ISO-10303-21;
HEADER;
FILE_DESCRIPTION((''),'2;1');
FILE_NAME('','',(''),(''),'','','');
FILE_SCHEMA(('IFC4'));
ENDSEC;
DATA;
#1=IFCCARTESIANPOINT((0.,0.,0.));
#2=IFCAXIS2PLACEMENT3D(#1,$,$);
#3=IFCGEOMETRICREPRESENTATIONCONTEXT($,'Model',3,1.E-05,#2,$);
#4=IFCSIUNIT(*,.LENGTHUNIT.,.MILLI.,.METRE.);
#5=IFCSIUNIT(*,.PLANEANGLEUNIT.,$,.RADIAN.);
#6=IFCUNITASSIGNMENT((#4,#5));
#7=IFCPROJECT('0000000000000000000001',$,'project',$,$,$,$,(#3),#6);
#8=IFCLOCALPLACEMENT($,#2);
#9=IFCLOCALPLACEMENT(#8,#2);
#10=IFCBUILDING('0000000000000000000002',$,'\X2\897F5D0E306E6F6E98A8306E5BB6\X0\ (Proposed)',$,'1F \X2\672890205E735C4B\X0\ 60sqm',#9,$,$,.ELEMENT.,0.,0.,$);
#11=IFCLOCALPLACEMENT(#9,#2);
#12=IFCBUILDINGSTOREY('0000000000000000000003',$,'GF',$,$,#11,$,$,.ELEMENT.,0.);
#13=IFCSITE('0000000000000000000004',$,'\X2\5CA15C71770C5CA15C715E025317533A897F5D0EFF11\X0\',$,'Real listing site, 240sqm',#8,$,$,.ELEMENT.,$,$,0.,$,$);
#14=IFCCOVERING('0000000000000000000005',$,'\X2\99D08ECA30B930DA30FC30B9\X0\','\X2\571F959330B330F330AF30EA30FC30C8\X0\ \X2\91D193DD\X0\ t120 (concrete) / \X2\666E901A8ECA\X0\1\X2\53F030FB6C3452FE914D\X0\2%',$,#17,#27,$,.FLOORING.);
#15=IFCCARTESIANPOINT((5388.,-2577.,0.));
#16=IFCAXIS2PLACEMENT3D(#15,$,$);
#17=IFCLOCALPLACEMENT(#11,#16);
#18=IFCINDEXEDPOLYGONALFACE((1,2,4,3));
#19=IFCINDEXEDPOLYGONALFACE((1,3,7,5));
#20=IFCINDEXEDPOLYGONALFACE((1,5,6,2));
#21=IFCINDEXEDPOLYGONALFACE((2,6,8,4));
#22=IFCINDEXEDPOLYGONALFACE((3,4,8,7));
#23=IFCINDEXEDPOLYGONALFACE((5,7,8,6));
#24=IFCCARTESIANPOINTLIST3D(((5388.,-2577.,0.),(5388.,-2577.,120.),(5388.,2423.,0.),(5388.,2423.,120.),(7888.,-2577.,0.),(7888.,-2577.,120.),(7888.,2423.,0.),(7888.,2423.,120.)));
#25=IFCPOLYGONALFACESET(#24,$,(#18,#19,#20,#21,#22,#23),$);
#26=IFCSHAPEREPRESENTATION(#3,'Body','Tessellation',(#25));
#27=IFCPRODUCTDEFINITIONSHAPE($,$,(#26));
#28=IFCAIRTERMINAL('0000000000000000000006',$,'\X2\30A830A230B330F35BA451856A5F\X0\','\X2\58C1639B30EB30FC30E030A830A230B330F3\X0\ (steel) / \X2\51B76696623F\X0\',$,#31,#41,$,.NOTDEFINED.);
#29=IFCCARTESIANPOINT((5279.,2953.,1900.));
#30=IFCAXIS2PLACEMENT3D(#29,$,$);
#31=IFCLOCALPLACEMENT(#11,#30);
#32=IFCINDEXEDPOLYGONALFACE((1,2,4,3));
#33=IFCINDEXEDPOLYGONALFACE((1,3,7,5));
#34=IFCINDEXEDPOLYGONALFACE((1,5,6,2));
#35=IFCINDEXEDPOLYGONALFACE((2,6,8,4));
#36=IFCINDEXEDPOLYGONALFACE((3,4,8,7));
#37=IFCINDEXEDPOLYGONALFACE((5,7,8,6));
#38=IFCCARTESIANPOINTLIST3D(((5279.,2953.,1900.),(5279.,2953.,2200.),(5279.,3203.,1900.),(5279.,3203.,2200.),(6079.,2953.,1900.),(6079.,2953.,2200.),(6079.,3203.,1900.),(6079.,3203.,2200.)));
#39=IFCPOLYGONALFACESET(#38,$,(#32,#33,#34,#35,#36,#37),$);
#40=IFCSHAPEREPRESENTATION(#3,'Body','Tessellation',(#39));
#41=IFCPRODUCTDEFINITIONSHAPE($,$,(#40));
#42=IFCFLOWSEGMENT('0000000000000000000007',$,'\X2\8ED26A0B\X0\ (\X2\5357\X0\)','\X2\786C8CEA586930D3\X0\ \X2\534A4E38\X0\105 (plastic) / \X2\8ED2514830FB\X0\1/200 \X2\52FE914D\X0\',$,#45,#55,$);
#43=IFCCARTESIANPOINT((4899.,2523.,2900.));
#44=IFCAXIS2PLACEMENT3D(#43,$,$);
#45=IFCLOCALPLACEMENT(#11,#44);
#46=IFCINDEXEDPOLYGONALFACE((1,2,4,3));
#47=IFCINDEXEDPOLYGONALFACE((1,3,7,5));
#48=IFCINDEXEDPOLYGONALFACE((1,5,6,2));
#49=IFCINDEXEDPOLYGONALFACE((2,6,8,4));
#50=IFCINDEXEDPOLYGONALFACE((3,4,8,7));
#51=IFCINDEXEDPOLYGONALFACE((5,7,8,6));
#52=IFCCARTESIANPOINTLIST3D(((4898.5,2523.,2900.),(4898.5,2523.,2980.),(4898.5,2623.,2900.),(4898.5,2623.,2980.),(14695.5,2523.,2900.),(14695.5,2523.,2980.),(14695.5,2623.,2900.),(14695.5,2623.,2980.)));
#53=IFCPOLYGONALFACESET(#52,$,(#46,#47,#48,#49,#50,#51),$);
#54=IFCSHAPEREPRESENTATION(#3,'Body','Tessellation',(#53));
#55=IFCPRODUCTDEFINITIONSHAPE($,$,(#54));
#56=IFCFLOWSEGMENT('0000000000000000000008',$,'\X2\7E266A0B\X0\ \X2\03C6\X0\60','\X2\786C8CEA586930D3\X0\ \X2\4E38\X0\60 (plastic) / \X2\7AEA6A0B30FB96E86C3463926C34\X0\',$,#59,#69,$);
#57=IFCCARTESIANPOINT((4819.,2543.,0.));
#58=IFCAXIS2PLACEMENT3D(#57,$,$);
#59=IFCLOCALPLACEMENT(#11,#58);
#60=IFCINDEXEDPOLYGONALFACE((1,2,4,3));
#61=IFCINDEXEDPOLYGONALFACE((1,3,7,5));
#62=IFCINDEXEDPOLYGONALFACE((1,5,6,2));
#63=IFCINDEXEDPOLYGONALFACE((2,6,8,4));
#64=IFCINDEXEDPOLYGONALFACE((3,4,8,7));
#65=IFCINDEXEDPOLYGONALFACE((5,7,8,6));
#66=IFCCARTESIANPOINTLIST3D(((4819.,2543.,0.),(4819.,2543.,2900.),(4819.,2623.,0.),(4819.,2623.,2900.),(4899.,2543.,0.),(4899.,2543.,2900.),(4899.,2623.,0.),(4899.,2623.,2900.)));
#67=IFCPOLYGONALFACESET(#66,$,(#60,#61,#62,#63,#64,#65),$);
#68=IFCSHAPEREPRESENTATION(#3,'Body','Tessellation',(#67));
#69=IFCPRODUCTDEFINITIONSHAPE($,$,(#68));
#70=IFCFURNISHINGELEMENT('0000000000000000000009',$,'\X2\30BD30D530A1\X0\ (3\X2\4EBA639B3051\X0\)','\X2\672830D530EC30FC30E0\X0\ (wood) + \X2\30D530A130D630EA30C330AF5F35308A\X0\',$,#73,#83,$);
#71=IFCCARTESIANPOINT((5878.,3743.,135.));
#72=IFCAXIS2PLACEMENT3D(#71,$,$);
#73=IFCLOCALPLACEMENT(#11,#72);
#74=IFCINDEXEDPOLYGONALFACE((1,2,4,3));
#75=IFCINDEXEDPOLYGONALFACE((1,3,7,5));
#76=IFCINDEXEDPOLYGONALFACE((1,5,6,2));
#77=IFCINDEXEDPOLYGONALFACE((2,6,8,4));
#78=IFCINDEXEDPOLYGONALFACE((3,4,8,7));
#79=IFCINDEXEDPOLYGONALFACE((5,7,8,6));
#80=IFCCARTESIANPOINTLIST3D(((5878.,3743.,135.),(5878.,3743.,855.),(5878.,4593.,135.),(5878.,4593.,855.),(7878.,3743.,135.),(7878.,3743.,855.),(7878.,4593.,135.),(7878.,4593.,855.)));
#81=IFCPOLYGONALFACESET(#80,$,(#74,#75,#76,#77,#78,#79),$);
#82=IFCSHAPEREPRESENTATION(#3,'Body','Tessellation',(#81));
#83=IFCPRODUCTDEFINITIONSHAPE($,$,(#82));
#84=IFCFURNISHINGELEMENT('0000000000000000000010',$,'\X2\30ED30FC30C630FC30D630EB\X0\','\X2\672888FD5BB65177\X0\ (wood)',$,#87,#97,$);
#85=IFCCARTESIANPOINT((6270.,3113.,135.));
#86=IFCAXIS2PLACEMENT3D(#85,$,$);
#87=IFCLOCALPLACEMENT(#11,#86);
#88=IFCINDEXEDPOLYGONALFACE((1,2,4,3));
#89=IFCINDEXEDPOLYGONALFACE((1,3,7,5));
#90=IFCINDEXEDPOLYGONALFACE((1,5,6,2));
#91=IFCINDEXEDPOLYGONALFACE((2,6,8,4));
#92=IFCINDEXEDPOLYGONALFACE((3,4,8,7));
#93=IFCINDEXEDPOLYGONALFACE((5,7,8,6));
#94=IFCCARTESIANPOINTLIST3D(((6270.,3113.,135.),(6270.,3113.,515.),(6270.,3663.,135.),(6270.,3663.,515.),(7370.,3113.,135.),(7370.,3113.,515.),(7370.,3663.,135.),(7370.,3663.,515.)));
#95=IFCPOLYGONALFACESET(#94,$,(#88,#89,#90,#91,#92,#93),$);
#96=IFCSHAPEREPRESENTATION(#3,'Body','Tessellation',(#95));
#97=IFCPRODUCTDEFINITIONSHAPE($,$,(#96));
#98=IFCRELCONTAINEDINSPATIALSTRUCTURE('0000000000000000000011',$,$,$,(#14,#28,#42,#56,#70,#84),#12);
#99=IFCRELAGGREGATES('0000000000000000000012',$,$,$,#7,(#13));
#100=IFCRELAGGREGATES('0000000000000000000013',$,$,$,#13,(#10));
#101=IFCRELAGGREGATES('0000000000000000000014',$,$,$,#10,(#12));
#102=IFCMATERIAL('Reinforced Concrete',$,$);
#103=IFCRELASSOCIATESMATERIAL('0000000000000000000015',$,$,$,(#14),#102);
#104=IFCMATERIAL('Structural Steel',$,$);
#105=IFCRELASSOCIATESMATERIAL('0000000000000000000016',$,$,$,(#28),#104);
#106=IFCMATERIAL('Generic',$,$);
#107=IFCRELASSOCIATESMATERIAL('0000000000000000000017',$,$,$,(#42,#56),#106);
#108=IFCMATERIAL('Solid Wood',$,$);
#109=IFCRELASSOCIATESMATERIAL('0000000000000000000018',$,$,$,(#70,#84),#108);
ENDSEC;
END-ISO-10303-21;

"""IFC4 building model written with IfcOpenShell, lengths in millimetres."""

from ifc_helpers import new_model, si_unit, frame, frame_2d, origin, place, context, project, spatial, rectangle, extrude, material, element, save


model = new_model("IFC4")

# Units and contexts
model_context = context("Model", 3, precision=1e-05, world=origin())
ifc_project = project(units=[si_unit("LENGTHUNIT", "METRE", prefix="MILLI"), si_unit("PLANEANGLEUNIT", "RADIAN")], contexts=[model_context])

# Site, building, storey
site_placement = place(None, origin())
site = spatial("IfcSite", under=ifc_project, at=site_placement, Name="岡山県岡山市北区西崎１", ObjectType="Real listing site, 240sqm", CompositionType="ELEMENT", RefElevation=0.0)
building_placement = place(site_placement, origin())
building = spatial("IfcBuilding", under=site, at=building_placement, Name="西崎の潮風の家 (Proposed)", ObjectType="1F 木造平屋 60sqm", CompositionType="ELEMENT", ElevationOfRefHeight=0.0, ElevationOfTerrain=0.0)
storey_placement = place(building_placement, origin())
storey = spatial("IfcBuildingStorey", under=building, at=storey_placement, Name="GF", CompositionType="ELEMENT", Elevation=0.0)

# Shared definitions
ifc_material_1 = material(Name="Solid Wood")

# Shared definitions
ifc_material_2 = material(Name="Reinforced Concrete")

# Shared definitions
ifc_material_3 = material(Name="Structural Steel")

# Covering
ifc_material_4 = material(Name="Generic")
covering_1_placement = place(storey_placement, frame((5388.0, -2577.0, 0.0)))
element("IfcCovering", 1, at=covering_1_placement, inside=storey, material=ifc_material_2, Name="駐車スペース", Description="土間コンクリート 金鏝 t120 (concrete) / 普通車1台・水勾配2%", PredefinedType="FLOORING", context=model_context, shape_type="SweptSolid", body=[
    extrude(rectangle(XDim=2500.0, YDim=5000.0, at=frame_2d((1250.0, 2500.0))), frame((5388.0, -2577.0, 0.0)), (0.0, 0.0, 1.0), 120.0),
])

# Air terminal
air_terminal_placement = place(storey_placement, frame((5279.0, 2953.0, 1900.0)))
element("IfcAirTerminal", 2, at=air_terminal_placement, inside=storey, material=ifc_material_3, Name="エアコン室内機", Description="壁掛ルームエアコン (steel) / 冷暖房", PredefinedType="NOTDEFINED", context=model_context, shape_type="SweptSolid", body=[
    extrude(rectangle(XDim=800.0, YDim=250.0, at=frame_2d((400.0, 125.0))), frame((5279.0, 2953.0, 1900.0)), (0.0, 0.0, 1.0), 300.0),
])

# Flow segments
flow_segment_1_placement = place(storey_placement, frame((4899.0, 2523.0, 2900.0)))
element("IfcFlowSegment", 3, at=flow_segment_1_placement, inside=storey, material=ifc_material_4, Name="軒樋 (南)", Description="硬質塩ビ 半丸105 (plastic) / 軒先・1/200 勾配", context=model_context, shape_type="SweptSolid", body=[
    extrude(rectangle(XDim=9797.0, YDim=100.0, at=frame_2d((4898.0, 50.0))), frame((4899.0, 2523.0, 2900.0)), (0.0, 0.0, 1.0), 80.0),
])
flow_segment_2_placement = place(storey_placement, frame((4819.0, 2543.0, 0.0)))
element("IfcFlowSegment", 4, at=flow_segment_2_placement, inside=storey, material=ifc_material_4, Name="縦樋 φ60", Description="硬質塩ビ 丸60 (plastic) / 竪樋・雨水排水", context=model_context, shape_type="SweptSolid", body=[
    extrude(rectangle(XDim=80.0, YDim=80.0, at=frame_2d((40.0, 40.0))), frame((4819.0, 2543.0, 0.0)), (0.0, 0.0, 1.0), 2900.0),
])

# Furnishing elements
furnishing_1_placement = place(storey_placement, frame((5878.0, 3743.0, 135.0)))
element("IfcFurnishingElement", 5, at=furnishing_1_placement, inside=storey, material=ifc_material_1, Name="ソファ (3人掛け)", Description="木フレーム (wood) + ファブリック張り", context=model_context, shape_type="SweptSolid", body=[
    extrude(rectangle(XDim=2000.0, YDim=850.0, at=frame_2d((1000.0, 425.0))), frame((5878.0, 3743.0, 135.0)), (0.0, 0.0, 1.0), 720.0),
])
furnishing_2_placement = place(storey_placement, frame((6270.0, 3113.0, 135.0)))
element("IfcFurnishingElement", 6, at=furnishing_2_placement, inside=storey, material=ifc_material_1, Name="ローテーブル", Description="木製家具 (wood)", context=model_context, shape_type="SweptSolid", body=[
    extrude(rectangle(XDim=1100.0, YDim=550.0, at=frame_2d((550.0, 275.0))), frame((6270.0, 3113.0, 135.0)), (0.0, 0.0, 1.0), 380.0),
])

save(model, "model.ifc")
